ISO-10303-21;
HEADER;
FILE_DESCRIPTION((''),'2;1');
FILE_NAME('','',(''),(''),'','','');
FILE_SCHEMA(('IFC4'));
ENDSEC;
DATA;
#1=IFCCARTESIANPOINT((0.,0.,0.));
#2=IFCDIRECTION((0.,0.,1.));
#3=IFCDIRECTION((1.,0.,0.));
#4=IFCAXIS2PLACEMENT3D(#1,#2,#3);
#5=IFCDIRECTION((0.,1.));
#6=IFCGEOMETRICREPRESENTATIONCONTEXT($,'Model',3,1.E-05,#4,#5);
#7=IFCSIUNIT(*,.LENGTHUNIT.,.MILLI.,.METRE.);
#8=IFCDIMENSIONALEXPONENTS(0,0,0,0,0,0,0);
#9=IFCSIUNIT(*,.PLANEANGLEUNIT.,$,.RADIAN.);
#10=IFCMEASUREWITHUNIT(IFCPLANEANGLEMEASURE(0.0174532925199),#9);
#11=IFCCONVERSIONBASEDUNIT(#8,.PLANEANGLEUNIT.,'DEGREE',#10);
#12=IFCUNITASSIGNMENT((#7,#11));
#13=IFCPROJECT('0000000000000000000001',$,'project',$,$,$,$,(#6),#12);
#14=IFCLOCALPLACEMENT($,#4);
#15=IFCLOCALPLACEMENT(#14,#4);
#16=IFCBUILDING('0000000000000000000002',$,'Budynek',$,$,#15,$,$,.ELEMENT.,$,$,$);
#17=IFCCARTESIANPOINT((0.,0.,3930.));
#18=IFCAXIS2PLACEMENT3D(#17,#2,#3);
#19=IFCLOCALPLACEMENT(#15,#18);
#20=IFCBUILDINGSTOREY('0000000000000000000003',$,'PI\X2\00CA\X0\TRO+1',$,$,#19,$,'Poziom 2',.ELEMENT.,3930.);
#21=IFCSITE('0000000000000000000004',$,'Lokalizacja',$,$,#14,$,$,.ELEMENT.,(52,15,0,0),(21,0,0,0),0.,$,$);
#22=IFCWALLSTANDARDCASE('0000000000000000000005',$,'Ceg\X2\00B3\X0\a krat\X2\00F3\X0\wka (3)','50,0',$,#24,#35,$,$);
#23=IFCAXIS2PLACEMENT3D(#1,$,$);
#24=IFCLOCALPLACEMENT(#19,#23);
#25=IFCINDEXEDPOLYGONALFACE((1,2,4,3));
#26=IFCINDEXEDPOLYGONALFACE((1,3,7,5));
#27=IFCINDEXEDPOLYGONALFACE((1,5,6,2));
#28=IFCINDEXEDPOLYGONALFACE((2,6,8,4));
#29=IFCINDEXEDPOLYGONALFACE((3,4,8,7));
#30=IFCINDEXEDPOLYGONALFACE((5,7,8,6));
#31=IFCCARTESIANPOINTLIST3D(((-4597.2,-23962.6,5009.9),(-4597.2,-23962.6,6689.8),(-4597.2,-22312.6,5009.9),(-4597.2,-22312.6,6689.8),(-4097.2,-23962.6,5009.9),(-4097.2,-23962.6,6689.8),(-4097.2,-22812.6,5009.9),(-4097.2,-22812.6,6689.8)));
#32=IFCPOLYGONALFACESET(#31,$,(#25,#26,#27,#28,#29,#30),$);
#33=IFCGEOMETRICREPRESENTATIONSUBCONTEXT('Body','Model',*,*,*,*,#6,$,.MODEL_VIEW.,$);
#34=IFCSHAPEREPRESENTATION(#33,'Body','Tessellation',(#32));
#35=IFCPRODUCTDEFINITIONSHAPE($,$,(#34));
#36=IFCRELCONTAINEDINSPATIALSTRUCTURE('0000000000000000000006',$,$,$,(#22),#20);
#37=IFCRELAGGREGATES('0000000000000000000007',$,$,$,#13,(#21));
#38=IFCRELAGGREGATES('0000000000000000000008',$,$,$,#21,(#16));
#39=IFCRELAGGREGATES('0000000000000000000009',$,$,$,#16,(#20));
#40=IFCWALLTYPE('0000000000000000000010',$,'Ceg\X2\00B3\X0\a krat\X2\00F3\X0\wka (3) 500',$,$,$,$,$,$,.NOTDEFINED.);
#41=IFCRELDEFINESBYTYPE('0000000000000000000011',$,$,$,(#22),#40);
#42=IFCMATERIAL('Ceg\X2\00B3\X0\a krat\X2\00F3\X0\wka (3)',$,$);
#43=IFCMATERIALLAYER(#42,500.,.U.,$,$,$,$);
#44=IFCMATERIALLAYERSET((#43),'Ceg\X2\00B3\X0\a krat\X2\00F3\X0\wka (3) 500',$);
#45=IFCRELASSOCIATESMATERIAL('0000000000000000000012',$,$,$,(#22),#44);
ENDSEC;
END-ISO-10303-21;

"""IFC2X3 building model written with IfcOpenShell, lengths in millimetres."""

from ifc_helpers import new_model, entity, si_unit, converted_unit, direction, frame, origin_with_axes, place, context, subcontext, project, spatial, polyline, outline, extrude, material, layer, layer_set, layer_usage, type_object, element, save


model = new_model("IFC2X3")

# Units and contexts
model_context = context("Model", 3, precision=1e-05, world=origin_with_axes(), true_north=direction((0.0, 1.0)))
body_context = subcontext(model_context, "Body", "Model", "MODEL_VIEW")
ifc_project = project(units=[si_unit("LENGTHUNIT", "METRE", prefix="MILLI"), converted_unit("PLANEANGLEUNIT", "DEGREE", entity("IfcPlaneAngleMeasure", 0.0174532925199), si_unit("PLANEANGLEUNIT", "RADIAN"), dimensions=[0, 0, 0, 0, 0, 0, 0])], contexts=[model_context])

# Site, building, storey
site_placement = place(None, origin_with_axes())
site = spatial("IfcSite", under=ifc_project, at=site_placement, Name="Lokalizacja", CompositionType="ELEMENT", RefLatitude=(52, 15, 0, 0), RefLongitude=(21, 0, 0, 0), RefElevation=0.0)
building_placement = place(site_placement, origin_with_axes())
building = spatial("IfcBuilding", under=site, at=building_placement, Name="Budynek", CompositionType="ELEMENT")
storey_placement = place(building_placement, frame((0.0, 0.0, 3930.0), z_axis=(0.0, 0.0, 1.0), x_axis=(1.0, 0.0, 0.0)))
storey = spatial("IfcBuildingStorey", under=building, at=storey_placement, Name="PIÊTRO+1", LongName="Poziom 2", CompositionType="ELEMENT", Elevation=3930.0)

# Wall
ifc_material = material(Name="Ceg³a kratówka (3)")
ifc_layer = layer(ifc_material, 500.0, ventilated="UNKNOWN")
ifc_layer_set = layer_set([ifc_layer], Name="Ceg³a kratówka (3) 500")
ifc_layer_usage = layer_usage(ifc_layer_set, "AXIS2", "NEGATIVE", 0.0)
wall_type_1 = type_object("IfcWallType", Name="Ceg³a kratówka (3) 500", PredefinedType="NOTDEFINED")
wall_placement = place(storey_placement, frame((-4597.2, -23962.6, 5009.9), z_axis=(0.0, 0.0, 1.0), x_axis=(0.0, 1.0, 0.0)))
element("IfcWallStandardCase", 1, at=wall_placement, inside=storey, type_object=wall_type_1, material=ifc_layer_usage, Name="Ceg³a kratówka (3)", Description="50,0", context=body_context, shape_type="SweptSolid", body=[
    extrude(outline(polyline([(0.0, -500.0), (1150.0, -500.0), (1650.0, 0.0), (0.0, 0.0), (0.0, -500.0)])), origin_with_axes(), (0.0, 0.0, 1.0), 1679.9),
])

save(model, "model.ifc")
